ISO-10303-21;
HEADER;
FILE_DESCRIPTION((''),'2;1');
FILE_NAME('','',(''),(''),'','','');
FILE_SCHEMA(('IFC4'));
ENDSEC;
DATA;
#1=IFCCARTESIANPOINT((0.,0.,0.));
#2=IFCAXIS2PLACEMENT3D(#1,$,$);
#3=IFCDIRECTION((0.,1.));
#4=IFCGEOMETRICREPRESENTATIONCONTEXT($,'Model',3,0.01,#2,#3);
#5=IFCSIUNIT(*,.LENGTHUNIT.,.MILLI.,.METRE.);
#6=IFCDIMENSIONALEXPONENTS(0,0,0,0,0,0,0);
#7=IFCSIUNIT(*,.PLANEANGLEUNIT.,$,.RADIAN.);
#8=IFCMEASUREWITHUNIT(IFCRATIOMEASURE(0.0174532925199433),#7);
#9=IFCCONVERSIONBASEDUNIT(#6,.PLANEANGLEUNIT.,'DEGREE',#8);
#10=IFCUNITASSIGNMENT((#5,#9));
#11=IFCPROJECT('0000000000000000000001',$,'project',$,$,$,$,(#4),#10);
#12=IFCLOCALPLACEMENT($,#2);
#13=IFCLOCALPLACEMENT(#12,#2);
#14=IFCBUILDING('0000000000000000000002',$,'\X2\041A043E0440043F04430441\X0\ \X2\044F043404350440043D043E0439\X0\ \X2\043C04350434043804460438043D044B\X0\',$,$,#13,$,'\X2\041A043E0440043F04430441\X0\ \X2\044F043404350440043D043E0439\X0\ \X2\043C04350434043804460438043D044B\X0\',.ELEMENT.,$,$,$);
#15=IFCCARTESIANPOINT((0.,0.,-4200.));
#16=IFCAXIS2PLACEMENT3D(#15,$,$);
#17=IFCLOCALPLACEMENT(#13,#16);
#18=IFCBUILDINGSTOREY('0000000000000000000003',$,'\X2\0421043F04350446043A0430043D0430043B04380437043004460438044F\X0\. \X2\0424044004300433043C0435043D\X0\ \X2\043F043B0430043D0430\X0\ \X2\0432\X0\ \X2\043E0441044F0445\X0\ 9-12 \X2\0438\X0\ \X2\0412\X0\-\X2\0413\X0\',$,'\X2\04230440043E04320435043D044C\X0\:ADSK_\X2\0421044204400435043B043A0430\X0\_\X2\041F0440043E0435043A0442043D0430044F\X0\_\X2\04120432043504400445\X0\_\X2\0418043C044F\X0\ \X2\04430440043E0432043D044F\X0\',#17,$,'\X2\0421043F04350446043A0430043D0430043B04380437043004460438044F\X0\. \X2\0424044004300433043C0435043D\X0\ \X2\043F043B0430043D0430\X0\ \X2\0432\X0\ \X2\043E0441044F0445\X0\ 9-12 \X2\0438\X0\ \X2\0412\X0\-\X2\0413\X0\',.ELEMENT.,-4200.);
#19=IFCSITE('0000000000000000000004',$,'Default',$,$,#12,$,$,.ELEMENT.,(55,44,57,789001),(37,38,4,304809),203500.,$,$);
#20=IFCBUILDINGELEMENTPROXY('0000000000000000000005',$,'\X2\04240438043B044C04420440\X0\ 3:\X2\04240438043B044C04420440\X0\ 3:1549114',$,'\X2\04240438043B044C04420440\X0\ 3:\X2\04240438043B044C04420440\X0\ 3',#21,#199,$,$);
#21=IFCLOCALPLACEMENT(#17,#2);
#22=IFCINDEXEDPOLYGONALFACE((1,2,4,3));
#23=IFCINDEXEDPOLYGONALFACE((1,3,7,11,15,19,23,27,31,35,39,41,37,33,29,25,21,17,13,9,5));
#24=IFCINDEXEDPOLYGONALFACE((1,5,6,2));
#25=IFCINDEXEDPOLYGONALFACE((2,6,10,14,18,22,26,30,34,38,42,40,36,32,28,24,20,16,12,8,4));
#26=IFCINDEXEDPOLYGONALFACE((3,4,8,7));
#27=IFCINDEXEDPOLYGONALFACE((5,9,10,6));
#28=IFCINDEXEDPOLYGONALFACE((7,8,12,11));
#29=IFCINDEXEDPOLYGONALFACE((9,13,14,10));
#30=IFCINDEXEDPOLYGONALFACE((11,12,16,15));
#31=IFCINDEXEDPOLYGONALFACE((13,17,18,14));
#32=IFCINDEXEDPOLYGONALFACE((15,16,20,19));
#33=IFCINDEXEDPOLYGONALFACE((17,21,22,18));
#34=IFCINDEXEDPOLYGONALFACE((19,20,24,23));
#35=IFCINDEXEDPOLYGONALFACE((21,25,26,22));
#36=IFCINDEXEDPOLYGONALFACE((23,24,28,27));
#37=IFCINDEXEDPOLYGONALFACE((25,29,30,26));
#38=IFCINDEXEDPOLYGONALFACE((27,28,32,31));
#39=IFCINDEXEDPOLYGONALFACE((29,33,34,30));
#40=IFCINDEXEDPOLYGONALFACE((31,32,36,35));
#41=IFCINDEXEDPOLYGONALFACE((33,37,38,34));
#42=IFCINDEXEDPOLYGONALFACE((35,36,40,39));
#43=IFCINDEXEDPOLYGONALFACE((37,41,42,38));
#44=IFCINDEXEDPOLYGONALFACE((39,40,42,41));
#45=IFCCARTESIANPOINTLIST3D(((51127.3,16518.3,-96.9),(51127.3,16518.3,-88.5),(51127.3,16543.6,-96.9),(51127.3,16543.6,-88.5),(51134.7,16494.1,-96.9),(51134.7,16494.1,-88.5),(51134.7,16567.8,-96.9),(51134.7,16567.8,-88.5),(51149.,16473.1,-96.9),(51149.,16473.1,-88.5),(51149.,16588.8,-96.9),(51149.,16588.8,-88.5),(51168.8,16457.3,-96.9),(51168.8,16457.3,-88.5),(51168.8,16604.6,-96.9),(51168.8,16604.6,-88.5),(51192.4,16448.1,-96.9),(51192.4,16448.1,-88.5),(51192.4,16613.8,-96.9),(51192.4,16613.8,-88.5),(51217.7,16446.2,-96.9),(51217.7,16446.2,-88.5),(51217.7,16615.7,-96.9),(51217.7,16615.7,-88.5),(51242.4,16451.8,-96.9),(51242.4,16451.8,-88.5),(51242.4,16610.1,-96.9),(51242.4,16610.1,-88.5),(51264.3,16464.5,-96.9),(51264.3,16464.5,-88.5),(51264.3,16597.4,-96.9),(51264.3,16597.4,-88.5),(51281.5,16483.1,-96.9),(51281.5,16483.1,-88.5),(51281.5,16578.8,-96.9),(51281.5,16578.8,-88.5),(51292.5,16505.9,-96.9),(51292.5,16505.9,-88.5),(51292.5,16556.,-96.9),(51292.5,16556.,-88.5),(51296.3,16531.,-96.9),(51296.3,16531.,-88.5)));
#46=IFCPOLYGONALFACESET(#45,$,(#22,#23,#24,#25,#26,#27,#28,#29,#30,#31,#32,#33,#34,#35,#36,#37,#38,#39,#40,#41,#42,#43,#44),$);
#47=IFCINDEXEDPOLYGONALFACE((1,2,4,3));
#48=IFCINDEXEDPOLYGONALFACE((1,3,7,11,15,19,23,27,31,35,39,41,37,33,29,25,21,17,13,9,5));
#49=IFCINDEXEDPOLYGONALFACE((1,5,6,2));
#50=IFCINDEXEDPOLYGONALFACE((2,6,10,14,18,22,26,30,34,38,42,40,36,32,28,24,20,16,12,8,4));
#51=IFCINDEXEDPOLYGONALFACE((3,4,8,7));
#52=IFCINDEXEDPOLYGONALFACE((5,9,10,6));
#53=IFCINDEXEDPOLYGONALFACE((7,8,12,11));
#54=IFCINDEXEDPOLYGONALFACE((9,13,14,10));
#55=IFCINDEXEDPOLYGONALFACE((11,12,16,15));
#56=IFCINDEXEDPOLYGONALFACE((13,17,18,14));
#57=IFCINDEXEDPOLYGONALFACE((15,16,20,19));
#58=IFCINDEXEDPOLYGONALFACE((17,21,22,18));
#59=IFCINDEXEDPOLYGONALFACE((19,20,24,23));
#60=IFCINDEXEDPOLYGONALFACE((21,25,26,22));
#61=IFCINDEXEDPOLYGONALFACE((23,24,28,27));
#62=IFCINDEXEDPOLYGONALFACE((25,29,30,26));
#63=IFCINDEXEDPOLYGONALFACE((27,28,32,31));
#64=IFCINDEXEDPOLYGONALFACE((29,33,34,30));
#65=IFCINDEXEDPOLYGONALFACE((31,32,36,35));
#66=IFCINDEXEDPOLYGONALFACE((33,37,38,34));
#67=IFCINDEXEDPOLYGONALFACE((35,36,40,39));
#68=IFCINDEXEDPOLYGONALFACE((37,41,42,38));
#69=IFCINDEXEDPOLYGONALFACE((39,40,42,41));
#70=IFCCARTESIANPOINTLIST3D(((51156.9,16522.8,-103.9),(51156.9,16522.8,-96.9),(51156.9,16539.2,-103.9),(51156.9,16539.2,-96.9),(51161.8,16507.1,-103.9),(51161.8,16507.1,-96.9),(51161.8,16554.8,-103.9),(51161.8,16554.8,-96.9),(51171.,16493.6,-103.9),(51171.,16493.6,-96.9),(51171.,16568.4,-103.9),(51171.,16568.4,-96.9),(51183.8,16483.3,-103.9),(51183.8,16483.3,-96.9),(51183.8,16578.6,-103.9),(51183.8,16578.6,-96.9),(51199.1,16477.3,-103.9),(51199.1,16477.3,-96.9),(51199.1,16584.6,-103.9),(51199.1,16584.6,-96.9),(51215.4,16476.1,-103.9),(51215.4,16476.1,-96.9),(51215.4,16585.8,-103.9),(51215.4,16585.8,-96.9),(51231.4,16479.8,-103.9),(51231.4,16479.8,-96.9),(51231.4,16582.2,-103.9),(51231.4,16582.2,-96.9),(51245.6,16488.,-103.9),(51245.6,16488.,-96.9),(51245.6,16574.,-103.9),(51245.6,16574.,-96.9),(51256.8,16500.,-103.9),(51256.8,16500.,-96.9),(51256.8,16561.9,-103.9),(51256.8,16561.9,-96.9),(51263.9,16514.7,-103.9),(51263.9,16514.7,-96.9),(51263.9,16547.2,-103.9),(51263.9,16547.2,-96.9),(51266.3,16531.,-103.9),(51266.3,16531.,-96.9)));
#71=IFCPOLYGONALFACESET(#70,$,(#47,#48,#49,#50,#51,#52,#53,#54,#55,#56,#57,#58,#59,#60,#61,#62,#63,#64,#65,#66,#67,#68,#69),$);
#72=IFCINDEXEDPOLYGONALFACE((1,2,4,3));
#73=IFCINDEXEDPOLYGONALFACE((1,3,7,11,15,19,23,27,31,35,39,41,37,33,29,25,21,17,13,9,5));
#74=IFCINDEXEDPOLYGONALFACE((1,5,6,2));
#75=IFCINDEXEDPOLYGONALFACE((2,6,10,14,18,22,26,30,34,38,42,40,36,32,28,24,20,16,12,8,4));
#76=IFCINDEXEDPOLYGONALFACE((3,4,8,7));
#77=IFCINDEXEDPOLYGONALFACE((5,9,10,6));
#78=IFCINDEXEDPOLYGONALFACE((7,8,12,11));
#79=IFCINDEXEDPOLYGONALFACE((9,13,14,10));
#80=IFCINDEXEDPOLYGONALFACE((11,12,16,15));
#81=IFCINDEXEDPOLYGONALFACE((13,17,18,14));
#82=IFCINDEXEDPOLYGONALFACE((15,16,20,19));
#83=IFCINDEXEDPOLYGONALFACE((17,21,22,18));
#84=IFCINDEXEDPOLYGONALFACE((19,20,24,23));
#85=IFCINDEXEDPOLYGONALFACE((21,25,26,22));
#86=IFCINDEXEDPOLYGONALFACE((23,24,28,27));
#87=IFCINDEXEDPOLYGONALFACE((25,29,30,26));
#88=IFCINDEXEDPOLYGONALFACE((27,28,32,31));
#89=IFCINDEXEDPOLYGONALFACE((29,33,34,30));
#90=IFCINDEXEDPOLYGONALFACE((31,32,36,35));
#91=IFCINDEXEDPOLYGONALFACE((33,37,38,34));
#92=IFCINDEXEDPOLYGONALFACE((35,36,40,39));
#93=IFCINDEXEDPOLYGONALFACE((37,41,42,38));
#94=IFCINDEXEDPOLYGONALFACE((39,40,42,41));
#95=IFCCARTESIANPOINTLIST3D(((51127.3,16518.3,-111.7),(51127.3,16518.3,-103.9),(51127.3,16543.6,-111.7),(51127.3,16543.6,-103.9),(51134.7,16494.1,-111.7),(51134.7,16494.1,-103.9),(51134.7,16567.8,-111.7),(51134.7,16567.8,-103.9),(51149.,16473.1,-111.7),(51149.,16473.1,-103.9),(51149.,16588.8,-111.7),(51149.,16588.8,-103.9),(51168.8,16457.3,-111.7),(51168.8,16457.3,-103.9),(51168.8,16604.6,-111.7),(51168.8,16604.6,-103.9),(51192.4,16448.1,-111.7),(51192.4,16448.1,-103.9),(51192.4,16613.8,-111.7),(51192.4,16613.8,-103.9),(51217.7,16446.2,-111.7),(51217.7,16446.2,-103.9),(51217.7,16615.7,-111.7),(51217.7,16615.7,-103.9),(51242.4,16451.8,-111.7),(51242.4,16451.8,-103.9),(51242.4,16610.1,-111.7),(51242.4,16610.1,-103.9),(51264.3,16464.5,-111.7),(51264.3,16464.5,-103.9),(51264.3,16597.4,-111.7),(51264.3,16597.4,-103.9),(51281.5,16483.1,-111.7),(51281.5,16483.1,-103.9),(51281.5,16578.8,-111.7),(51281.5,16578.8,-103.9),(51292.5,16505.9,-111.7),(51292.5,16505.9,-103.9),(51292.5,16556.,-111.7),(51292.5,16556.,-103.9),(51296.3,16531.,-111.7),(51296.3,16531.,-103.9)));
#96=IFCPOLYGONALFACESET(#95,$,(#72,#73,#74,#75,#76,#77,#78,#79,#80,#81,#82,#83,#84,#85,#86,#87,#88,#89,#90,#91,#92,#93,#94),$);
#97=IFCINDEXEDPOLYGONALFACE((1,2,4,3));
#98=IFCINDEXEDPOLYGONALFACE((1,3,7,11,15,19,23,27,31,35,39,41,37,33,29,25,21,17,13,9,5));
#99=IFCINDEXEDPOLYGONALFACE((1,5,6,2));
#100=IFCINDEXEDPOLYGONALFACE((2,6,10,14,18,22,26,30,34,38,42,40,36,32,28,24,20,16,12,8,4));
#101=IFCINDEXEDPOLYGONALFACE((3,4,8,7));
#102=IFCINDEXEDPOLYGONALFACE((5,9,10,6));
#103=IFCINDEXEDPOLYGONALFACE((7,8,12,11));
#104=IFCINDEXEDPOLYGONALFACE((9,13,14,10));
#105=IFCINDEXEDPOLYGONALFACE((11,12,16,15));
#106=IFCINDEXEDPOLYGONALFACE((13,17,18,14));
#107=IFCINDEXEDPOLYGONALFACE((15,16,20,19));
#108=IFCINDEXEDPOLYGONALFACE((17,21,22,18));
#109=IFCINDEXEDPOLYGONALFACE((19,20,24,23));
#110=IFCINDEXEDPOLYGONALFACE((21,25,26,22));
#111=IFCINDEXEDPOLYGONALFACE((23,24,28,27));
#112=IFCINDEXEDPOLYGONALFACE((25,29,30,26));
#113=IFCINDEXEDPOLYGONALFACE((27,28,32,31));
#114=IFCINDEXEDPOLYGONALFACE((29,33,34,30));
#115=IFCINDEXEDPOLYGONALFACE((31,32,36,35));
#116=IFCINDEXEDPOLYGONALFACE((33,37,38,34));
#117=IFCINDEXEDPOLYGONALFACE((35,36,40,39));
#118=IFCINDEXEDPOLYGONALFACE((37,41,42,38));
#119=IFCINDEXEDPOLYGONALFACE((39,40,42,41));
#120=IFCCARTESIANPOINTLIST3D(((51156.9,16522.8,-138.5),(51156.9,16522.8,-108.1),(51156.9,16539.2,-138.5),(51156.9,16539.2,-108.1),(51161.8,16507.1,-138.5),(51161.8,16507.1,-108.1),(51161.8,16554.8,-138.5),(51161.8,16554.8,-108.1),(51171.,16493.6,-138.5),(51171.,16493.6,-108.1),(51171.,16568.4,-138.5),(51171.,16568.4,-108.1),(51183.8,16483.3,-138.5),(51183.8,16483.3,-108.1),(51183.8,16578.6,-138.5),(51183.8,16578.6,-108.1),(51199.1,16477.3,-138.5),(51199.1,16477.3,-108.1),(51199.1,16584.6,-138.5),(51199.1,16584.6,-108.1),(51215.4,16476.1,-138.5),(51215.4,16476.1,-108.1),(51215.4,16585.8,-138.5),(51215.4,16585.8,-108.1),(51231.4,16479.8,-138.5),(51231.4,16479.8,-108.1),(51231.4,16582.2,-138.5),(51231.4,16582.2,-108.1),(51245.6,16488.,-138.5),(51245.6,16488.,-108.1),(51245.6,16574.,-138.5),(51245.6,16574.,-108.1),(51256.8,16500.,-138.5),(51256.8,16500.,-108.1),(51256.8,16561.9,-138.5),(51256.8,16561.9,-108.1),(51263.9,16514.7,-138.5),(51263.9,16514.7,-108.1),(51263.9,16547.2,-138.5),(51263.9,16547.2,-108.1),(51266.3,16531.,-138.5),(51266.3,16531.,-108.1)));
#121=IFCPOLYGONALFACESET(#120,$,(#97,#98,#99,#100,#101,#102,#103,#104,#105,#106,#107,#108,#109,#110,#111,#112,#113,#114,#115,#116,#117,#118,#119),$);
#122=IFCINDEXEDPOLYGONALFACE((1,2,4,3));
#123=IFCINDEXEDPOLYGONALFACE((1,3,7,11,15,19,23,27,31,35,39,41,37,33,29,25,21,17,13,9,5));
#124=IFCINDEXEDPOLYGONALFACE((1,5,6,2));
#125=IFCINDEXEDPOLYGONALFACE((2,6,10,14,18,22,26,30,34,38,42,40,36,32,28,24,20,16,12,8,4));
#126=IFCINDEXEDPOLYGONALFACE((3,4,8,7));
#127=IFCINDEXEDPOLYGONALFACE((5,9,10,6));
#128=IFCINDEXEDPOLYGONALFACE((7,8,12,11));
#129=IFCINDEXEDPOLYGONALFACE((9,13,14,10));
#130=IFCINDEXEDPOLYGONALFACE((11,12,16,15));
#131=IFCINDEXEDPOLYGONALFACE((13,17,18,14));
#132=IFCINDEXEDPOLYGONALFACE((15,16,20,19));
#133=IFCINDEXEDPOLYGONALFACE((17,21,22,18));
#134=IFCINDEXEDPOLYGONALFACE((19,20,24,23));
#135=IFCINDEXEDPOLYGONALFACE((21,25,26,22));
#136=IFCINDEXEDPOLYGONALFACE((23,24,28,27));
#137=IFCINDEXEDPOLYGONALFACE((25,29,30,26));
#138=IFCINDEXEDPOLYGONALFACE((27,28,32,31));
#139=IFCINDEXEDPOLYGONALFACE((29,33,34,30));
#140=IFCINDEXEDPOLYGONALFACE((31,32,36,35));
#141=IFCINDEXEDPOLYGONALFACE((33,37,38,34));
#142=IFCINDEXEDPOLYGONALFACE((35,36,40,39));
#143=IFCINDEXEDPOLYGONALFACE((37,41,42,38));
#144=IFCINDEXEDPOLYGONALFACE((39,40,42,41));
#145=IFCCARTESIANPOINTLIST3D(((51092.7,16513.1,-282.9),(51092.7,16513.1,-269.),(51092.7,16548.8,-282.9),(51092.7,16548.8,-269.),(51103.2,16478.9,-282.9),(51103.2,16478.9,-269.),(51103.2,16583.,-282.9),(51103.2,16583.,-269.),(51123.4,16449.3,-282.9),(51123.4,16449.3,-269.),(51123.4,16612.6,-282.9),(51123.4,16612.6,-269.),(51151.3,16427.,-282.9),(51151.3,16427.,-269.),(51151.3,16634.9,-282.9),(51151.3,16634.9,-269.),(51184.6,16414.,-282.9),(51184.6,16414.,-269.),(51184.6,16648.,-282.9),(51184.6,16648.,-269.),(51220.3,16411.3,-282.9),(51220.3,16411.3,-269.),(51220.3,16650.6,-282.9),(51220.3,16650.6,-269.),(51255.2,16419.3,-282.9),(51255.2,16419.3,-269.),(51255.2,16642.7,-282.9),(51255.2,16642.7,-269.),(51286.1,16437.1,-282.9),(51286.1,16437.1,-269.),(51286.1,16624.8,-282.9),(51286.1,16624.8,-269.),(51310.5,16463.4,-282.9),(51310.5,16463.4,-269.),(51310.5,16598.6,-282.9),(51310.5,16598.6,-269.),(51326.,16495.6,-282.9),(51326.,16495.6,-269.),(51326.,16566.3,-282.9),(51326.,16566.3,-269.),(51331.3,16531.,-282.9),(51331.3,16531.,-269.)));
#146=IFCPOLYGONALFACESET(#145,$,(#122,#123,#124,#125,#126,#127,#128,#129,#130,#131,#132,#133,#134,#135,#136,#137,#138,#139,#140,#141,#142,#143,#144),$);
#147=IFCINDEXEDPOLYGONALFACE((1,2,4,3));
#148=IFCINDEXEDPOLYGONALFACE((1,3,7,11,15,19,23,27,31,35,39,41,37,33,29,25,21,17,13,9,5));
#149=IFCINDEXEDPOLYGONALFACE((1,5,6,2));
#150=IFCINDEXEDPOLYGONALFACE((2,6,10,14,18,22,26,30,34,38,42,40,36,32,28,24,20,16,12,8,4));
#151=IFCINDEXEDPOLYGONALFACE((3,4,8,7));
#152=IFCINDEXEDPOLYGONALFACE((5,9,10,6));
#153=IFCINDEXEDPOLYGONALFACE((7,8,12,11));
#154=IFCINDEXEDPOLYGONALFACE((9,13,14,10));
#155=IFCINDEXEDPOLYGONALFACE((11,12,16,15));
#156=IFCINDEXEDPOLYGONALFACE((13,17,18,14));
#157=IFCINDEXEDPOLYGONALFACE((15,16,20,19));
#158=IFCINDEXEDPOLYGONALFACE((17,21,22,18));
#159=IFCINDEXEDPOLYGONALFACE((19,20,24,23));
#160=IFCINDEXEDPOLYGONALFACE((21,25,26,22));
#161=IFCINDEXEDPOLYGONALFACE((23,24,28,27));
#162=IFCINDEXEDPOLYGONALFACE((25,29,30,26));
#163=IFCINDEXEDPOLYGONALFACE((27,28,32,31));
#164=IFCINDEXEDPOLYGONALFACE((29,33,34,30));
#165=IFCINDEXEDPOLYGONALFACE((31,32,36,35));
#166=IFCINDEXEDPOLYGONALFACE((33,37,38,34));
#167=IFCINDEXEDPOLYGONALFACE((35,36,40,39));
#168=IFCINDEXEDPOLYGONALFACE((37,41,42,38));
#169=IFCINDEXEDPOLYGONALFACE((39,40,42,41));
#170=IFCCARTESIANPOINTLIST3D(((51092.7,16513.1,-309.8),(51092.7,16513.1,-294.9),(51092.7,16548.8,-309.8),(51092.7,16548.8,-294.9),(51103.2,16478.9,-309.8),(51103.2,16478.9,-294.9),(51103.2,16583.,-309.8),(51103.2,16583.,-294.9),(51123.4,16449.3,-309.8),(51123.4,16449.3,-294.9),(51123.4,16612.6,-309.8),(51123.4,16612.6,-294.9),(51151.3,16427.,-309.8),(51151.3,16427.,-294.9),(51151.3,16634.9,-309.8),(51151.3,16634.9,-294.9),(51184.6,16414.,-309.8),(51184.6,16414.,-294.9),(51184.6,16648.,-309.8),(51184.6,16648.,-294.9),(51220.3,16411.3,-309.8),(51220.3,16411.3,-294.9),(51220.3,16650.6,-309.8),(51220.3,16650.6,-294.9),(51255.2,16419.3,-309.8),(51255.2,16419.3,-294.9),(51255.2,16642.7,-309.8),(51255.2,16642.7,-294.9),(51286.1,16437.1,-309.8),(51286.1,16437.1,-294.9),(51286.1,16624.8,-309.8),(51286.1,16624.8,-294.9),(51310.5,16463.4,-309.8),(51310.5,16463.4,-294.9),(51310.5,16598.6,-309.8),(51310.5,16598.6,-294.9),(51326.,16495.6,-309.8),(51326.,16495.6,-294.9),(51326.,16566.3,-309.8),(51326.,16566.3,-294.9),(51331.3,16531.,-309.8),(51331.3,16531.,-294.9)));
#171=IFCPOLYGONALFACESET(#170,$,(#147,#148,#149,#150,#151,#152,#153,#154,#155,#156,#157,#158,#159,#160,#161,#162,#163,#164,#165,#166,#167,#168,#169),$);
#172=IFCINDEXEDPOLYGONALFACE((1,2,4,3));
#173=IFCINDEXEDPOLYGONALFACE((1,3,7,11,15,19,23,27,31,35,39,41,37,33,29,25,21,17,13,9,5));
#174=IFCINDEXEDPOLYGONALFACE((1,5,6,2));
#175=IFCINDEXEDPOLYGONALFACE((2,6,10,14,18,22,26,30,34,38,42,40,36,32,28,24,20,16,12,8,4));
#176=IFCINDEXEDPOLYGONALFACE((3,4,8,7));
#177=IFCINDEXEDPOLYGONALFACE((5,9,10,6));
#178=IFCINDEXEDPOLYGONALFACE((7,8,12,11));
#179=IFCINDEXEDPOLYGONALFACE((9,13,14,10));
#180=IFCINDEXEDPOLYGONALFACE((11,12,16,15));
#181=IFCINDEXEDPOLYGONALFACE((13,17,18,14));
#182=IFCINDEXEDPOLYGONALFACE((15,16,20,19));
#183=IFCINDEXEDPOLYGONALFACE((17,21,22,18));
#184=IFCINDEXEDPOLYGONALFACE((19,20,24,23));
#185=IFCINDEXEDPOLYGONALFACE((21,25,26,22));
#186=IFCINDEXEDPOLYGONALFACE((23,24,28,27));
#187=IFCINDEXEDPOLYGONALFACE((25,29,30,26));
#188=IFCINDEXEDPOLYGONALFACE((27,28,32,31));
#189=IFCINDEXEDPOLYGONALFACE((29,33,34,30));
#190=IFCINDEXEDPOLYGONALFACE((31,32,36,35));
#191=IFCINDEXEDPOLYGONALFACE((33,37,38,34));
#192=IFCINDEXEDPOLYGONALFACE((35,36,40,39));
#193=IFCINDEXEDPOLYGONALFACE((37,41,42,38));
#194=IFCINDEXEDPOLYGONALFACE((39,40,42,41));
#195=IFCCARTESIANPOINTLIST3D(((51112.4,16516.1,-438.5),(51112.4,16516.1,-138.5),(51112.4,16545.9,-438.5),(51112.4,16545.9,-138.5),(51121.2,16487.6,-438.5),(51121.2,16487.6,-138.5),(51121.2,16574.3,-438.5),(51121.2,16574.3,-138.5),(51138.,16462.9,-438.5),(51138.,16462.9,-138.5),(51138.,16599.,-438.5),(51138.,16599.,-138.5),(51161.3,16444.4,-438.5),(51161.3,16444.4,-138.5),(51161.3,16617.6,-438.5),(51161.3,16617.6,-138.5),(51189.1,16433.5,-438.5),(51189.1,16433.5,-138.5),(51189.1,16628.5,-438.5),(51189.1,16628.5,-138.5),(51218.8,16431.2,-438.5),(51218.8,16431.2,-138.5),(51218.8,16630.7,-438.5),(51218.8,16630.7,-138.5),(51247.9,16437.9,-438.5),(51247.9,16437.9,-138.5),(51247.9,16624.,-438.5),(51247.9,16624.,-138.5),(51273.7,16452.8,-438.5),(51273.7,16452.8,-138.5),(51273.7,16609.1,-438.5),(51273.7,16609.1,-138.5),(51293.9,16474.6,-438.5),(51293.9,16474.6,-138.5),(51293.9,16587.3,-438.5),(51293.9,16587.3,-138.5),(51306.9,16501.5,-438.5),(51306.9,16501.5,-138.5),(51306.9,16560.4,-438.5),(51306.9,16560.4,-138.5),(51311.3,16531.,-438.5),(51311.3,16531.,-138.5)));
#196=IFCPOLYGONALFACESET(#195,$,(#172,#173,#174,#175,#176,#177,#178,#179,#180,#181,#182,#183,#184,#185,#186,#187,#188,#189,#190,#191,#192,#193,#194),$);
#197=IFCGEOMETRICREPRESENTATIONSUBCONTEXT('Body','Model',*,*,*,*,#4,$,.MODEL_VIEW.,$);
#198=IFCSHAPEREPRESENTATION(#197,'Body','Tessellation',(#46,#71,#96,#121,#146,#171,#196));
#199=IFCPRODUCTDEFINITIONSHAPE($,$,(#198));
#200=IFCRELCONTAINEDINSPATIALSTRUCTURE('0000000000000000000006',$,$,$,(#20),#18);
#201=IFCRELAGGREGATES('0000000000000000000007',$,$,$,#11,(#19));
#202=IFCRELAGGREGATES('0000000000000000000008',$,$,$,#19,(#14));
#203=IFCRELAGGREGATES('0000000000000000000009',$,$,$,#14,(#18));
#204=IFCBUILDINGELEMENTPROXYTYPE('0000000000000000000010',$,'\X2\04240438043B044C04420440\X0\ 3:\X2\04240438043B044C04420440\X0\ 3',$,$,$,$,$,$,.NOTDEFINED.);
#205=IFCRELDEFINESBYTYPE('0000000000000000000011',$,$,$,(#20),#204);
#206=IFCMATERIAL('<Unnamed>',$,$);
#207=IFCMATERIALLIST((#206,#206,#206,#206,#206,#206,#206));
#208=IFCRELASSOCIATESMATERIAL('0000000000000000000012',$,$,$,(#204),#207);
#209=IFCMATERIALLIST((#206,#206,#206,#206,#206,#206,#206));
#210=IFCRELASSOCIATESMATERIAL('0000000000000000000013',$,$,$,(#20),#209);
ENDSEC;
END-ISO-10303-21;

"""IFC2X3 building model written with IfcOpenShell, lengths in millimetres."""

from ifc_helpers import new_model, entity, si_unit, converted_unit, direction, frame, frame_2d, origin, place, context, subcontext, project, spatial, circle, extrude, source, transform, mapped, material, material_list, type_object, type_shapes, element, save


model = new_model("IFC2X3")

# Units and contexts
model_context = context("Model", 3, precision=0.01, world=origin(), true_north=direction((0.0, 1.0)))
body_context = subcontext(model_context, "Body", "Model", "MODEL_VIEW")
ifc_project = project(units=[si_unit("LENGTHUNIT", "METRE", prefix="MILLI"), converted_unit("PLANEANGLEUNIT", "DEGREE", entity("IfcRatioMeasure", 0.0174532925199433), si_unit("PLANEANGLEUNIT", "RADIAN"), dimensions=[0, 0, 0, 0, 0, 0, 0])], contexts=[model_context])

# Site, building, storey
site_placement = place(None, frame((0.0, 0.0, 0.0)))
site = spatial("IfcSite", under=ifc_project, at=site_placement, Name="Default", CompositionType="ELEMENT", RefLatitude=(55, 44, 57, 789001), RefLongitude=(37, 38, 4, 304809), RefElevation=203500.0)
building_placement = place(site_placement, origin())
building = spatial("IfcBuilding", under=site, at=building_placement, Name="Корпус ядерной медицины", LongName="Корпус ядерной медицины", CompositionType="ELEMENT")
storey_placement = place(building_placement, frame((0.0, 0.0, -4200.0)))
storey = spatial("IfcBuildingStorey", under=building, at=storey_placement, Name="Спецканализация. Фрагмен плана в осях 9-12 и В-Г", ObjectType="Уровень:ADSK_Стрелка_Проектная_Вверх_Имя уровня", LongName="Спецканализация. Фрагмен плана в осях 9-12 и В-Г", CompositionType="ELEMENT", Elevation=-4200.0)

# Building element proxy
ifc_material_1 = material(Name="<Unnamed>")
ifc_material_list_1 = material_list([ifc_material_1, ifc_material_1, ifc_material_1, ifc_material_1, ifc_material_1, ifc_material_1, ifc_material_1])
ifc_material_list_2 = material_list([ifc_material_1, ifc_material_1, ifc_material_1, ifc_material_1, ifc_material_1, ifc_material_1, ifc_material_1])
building_element_proxy_type_1 = type_object("IfcBuildingElementProxyType", Name="Фильтр 3:Фильтр 3", PredefinedType="NOTDEFINED", material=ifc_material_list_2)
shared_shape_1 = source(origin(), body_context, "Body", "SweptSolid", [
    extrude(circle(Radius=85.0, at=frame_2d((0.0, 0.0), x_axis=(1.0, 0.0))), frame((0.0, 0.0, 241.6)), (0.0, 0.0, 1.0), 8.4),
    extrude(circle(Radius=55.0, at=frame_2d((0.0, 0.0), x_axis=(1.0, 0.0))), frame((0.0, 0.0, 234.6)), (0.0, 0.0, 1.0), 7.0),
    extrude(circle(Radius=85.0, at=frame_2d((0.0, 0.0), x_axis=(1.0, 0.0))), frame((0.0, 0.0, 226.8)), (0.0, 0.0, 1.0), 7.9),
    extrude(circle(Radius=55.0, at=frame_2d((0.0, 0.0), x_axis=(1.0, 0.0))), frame((0.0, 0.0, 200.0)), (0.0, 0.0, 1.0), 30.4),
    extrude(circle(Radius=120.0, at=frame_2d((0.0, 0.0), x_axis=(1.0, 0.0))), frame((0.0, 0.0, 55.6)), (0.0, 0.0, 1.0), 13.9),
    extrude(circle(Radius=120.0, at=frame_2d((0.0, 0.0), x_axis=(1.0, 0.0))), frame((0.0, 0.0, 28.7)), (0.0, 0.0, 1.0), 14.9),
    extrude(circle(Radius=100.0, at=frame_2d((0.0, 0.0), x_axis=(1.0, 0.0))), frame((0.0, 0.0, -100.0)), (0.0, 0.0, 1.0), 300.0),
])
type_shapes(building_element_proxy_type_1, [shared_shape_1])
proxy_1_placement = place(storey_placement, frame((51211.3, 16531.0, -338.5)))
element("IfcBuildingElementProxy", 1, at=proxy_1_placement, inside=storey, type_object=building_element_proxy_type_1, material=ifc_material_list_1, Name="Фильтр 3:Фильтр 3:1549114", ObjectType="Фильтр 3:Фильтр 3", context=body_context, shape_type="MappedRepresentation", body=[
    mapped(shared_shape_1, transform((0.0, 0.0, 0.0), scale=1.0)),
])

save(model, "model.ifc")
